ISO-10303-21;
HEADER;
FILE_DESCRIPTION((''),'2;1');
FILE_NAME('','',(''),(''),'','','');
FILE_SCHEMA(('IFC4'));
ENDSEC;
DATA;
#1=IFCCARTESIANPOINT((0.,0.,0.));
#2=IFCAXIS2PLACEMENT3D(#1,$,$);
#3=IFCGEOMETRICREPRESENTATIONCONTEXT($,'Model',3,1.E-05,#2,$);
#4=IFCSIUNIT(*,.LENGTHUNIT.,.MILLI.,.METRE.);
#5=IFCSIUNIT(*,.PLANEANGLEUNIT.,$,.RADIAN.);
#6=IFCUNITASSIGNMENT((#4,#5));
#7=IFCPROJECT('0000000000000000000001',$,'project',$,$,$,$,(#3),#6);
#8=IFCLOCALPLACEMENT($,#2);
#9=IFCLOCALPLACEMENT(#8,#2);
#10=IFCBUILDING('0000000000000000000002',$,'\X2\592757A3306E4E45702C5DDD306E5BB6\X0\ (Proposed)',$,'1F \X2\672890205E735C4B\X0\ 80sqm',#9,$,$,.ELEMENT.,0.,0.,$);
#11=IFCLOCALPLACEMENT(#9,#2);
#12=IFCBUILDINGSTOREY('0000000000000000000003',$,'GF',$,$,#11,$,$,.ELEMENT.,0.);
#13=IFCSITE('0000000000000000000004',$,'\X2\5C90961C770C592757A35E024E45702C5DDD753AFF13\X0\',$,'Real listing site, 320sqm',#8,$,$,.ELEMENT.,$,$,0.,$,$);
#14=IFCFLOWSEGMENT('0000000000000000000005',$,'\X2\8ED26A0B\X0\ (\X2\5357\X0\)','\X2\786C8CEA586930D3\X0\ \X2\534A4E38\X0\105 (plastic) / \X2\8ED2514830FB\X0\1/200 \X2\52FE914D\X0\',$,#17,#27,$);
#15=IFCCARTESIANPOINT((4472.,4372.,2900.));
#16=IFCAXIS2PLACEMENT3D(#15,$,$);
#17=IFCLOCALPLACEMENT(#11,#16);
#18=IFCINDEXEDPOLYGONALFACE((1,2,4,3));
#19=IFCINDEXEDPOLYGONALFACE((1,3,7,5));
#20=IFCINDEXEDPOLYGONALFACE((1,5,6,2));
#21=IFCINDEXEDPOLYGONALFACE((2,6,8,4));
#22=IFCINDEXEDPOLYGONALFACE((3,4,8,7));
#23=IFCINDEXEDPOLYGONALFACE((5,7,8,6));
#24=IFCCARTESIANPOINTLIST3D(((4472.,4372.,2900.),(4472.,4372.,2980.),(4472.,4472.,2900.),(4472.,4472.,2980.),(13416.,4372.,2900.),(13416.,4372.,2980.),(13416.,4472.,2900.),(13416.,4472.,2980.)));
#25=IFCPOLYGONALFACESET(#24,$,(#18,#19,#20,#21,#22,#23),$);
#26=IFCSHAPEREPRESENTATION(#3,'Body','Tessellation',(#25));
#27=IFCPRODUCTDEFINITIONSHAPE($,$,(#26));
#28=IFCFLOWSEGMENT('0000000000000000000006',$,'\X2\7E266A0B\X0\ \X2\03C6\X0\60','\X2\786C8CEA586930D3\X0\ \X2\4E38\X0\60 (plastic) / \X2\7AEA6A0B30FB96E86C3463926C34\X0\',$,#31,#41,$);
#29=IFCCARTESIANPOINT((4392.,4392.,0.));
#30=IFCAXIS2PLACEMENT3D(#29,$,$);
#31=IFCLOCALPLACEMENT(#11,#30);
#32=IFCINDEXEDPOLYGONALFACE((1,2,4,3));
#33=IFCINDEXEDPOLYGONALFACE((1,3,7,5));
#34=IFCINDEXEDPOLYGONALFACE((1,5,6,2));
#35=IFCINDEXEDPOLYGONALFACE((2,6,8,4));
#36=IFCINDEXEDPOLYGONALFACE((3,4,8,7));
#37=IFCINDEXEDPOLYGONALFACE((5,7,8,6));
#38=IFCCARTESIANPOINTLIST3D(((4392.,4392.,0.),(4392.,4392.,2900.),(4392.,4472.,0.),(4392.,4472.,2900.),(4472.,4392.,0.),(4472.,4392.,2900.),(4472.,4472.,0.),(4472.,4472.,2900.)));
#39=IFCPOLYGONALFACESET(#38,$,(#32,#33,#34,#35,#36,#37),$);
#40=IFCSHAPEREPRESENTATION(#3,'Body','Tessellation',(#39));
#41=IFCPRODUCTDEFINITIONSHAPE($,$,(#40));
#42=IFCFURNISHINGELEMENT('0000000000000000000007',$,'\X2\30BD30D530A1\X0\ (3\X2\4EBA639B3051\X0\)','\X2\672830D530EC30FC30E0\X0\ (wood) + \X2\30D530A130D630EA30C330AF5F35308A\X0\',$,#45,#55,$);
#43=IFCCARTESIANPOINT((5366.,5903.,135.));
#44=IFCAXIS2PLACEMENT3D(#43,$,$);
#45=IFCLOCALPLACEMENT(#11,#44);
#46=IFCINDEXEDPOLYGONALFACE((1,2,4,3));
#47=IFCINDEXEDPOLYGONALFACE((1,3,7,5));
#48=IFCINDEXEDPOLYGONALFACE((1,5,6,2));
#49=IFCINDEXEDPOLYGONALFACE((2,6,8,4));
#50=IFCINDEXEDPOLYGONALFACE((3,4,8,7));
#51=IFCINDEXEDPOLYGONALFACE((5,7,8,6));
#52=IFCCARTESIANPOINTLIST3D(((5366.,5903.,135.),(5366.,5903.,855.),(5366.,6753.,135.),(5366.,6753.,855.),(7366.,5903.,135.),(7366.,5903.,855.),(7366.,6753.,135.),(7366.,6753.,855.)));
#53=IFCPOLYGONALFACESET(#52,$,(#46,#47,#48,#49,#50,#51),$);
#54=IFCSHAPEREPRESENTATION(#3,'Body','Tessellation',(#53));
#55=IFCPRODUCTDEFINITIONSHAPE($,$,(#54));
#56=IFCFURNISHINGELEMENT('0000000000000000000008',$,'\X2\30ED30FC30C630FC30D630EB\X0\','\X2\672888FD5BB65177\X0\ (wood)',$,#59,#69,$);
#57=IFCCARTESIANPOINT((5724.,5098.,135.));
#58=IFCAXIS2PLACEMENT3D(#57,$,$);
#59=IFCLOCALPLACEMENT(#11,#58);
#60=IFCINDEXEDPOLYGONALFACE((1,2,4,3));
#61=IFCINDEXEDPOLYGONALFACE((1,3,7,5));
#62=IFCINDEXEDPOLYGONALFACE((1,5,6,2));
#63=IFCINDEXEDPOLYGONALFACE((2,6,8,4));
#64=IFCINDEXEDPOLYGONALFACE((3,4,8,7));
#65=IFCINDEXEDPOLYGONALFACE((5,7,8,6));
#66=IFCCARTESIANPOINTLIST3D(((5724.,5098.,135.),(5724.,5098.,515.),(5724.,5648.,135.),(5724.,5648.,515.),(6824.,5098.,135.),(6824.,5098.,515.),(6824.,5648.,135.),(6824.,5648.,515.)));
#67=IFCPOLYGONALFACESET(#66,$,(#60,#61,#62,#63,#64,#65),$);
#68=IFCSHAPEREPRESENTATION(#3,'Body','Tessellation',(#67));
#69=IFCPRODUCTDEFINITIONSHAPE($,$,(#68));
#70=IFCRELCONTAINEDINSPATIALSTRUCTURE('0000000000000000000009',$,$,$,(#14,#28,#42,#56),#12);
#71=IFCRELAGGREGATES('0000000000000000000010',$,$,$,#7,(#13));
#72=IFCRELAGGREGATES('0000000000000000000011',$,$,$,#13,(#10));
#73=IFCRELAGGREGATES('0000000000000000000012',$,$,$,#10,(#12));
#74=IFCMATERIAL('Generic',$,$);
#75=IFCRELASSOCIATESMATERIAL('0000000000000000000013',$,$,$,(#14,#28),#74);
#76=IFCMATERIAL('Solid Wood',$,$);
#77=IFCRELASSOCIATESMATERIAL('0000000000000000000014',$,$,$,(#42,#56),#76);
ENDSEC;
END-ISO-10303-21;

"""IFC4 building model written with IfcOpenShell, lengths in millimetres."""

from ifc_helpers import new_model, si_unit, frame, frame_2d, origin, place, context, project, spatial, rectangle, extrude, material, element, save


model = new_model("IFC4")

# Units and contexts
model_context = context("Model", 3, precision=1e-05, world=origin())
ifc_project = project(units=[si_unit("LENGTHUNIT", "METRE", prefix="MILLI"), si_unit("PLANEANGLEUNIT", "RADIAN")], contexts=[model_context])

# Site, building, storey
site_placement = place(None, origin())
site = spatial("IfcSite", under=ifc_project, at=site_placement, Name="岐阜県大垣市久瀬川町３", ObjectType="Real listing site, 320sqm", CompositionType="ELEMENT", RefElevation=0.0)
building_placement = place(site_placement, origin())
building = spatial("IfcBuilding", under=site, at=building_placement, Name="大垣の久瀬川の家 (Proposed)", ObjectType="1F 木造平屋 80sqm", CompositionType="ELEMENT", ElevationOfRefHeight=0.0, ElevationOfTerrain=0.0)
storey_placement = place(building_placement, origin())
storey = spatial("IfcBuildingStorey", under=building, at=storey_placement, Name="GF", CompositionType="ELEMENT", Elevation=0.0)

# Shared definitions
ifc_material_1 = material(Name="Solid Wood")

# Shared definitions
ifc_material_2 = material(Name="Generic")

# Flow segments
flow_segment_1_placement = place(storey_placement, frame((4472.0, 4372.0, 2900.0)))
element("IfcFlowSegment", 1, at=flow_segment_1_placement, inside=storey, material=ifc_material_2, Name="軒樋 (南)", Description="硬質塩ビ 半丸105 (plastic) / 軒先・1/200 勾配", context=model_context, shape_type="SweptSolid", body=[
    extrude(rectangle(XDim=8944.0, YDim=100.0, at=frame_2d((4472.0, 50.0))), frame((4472.0, 4372.0, 2900.0)), (0.0, 0.0, 1.0), 80.0),
])
flow_segment_2_placement = place(storey_placement, frame((4392.0, 4392.0, 0.0)))
element("IfcFlowSegment", 2, at=flow_segment_2_placement, inside=storey, material=ifc_material_2, Name="縦樋 φ60", Description="硬質塩ビ 丸60 (plastic) / 竪樋・雨水排水", context=model_context, shape_type="SweptSolid", body=[
    extrude(rectangle(XDim=80.0, YDim=80.0, at=frame_2d((40.0, 40.0))), frame((4392.0, 4392.0, 0.0)), (0.0, 0.0, 1.0), 2900.0),
])

# Furnishing elements
furnishing_1_placement = place(storey_placement, frame((5366.0, 5903.0, 135.0)))
element("IfcFurnishingElement", 3, at=furnishing_1_placement, inside=storey, material=ifc_material_1, Name="ソファ (3人掛け)", Description="木フレーム (wood) + ファブリック張り", context=model_context, shape_type="SweptSolid", body=[
    extrude(rectangle(XDim=2000.0, YDim=850.0, at=frame_2d((1000.0, 425.0))), frame((5366.0, 5903.0, 135.0)), (0.0, 0.0, 1.0), 720.0),
])
furnishing_2_placement = place(storey_placement, frame((5724.0, 5098.0, 135.0)))
element("IfcFurnishingElement", 4, at=furnishing_2_placement, inside=storey, material=ifc_material_1, Name="ローテーブル", Description="木製家具 (wood)", context=model_context, shape_type="SweptSolid", body=[
    extrude(rectangle(XDim=1100.0, YDim=550.0, at=frame_2d((550.0, 275.0))), frame((5724.0, 5098.0, 135.0)), (0.0, 0.0, 1.0), 380.0),
])

save(model, "model.ifc")
